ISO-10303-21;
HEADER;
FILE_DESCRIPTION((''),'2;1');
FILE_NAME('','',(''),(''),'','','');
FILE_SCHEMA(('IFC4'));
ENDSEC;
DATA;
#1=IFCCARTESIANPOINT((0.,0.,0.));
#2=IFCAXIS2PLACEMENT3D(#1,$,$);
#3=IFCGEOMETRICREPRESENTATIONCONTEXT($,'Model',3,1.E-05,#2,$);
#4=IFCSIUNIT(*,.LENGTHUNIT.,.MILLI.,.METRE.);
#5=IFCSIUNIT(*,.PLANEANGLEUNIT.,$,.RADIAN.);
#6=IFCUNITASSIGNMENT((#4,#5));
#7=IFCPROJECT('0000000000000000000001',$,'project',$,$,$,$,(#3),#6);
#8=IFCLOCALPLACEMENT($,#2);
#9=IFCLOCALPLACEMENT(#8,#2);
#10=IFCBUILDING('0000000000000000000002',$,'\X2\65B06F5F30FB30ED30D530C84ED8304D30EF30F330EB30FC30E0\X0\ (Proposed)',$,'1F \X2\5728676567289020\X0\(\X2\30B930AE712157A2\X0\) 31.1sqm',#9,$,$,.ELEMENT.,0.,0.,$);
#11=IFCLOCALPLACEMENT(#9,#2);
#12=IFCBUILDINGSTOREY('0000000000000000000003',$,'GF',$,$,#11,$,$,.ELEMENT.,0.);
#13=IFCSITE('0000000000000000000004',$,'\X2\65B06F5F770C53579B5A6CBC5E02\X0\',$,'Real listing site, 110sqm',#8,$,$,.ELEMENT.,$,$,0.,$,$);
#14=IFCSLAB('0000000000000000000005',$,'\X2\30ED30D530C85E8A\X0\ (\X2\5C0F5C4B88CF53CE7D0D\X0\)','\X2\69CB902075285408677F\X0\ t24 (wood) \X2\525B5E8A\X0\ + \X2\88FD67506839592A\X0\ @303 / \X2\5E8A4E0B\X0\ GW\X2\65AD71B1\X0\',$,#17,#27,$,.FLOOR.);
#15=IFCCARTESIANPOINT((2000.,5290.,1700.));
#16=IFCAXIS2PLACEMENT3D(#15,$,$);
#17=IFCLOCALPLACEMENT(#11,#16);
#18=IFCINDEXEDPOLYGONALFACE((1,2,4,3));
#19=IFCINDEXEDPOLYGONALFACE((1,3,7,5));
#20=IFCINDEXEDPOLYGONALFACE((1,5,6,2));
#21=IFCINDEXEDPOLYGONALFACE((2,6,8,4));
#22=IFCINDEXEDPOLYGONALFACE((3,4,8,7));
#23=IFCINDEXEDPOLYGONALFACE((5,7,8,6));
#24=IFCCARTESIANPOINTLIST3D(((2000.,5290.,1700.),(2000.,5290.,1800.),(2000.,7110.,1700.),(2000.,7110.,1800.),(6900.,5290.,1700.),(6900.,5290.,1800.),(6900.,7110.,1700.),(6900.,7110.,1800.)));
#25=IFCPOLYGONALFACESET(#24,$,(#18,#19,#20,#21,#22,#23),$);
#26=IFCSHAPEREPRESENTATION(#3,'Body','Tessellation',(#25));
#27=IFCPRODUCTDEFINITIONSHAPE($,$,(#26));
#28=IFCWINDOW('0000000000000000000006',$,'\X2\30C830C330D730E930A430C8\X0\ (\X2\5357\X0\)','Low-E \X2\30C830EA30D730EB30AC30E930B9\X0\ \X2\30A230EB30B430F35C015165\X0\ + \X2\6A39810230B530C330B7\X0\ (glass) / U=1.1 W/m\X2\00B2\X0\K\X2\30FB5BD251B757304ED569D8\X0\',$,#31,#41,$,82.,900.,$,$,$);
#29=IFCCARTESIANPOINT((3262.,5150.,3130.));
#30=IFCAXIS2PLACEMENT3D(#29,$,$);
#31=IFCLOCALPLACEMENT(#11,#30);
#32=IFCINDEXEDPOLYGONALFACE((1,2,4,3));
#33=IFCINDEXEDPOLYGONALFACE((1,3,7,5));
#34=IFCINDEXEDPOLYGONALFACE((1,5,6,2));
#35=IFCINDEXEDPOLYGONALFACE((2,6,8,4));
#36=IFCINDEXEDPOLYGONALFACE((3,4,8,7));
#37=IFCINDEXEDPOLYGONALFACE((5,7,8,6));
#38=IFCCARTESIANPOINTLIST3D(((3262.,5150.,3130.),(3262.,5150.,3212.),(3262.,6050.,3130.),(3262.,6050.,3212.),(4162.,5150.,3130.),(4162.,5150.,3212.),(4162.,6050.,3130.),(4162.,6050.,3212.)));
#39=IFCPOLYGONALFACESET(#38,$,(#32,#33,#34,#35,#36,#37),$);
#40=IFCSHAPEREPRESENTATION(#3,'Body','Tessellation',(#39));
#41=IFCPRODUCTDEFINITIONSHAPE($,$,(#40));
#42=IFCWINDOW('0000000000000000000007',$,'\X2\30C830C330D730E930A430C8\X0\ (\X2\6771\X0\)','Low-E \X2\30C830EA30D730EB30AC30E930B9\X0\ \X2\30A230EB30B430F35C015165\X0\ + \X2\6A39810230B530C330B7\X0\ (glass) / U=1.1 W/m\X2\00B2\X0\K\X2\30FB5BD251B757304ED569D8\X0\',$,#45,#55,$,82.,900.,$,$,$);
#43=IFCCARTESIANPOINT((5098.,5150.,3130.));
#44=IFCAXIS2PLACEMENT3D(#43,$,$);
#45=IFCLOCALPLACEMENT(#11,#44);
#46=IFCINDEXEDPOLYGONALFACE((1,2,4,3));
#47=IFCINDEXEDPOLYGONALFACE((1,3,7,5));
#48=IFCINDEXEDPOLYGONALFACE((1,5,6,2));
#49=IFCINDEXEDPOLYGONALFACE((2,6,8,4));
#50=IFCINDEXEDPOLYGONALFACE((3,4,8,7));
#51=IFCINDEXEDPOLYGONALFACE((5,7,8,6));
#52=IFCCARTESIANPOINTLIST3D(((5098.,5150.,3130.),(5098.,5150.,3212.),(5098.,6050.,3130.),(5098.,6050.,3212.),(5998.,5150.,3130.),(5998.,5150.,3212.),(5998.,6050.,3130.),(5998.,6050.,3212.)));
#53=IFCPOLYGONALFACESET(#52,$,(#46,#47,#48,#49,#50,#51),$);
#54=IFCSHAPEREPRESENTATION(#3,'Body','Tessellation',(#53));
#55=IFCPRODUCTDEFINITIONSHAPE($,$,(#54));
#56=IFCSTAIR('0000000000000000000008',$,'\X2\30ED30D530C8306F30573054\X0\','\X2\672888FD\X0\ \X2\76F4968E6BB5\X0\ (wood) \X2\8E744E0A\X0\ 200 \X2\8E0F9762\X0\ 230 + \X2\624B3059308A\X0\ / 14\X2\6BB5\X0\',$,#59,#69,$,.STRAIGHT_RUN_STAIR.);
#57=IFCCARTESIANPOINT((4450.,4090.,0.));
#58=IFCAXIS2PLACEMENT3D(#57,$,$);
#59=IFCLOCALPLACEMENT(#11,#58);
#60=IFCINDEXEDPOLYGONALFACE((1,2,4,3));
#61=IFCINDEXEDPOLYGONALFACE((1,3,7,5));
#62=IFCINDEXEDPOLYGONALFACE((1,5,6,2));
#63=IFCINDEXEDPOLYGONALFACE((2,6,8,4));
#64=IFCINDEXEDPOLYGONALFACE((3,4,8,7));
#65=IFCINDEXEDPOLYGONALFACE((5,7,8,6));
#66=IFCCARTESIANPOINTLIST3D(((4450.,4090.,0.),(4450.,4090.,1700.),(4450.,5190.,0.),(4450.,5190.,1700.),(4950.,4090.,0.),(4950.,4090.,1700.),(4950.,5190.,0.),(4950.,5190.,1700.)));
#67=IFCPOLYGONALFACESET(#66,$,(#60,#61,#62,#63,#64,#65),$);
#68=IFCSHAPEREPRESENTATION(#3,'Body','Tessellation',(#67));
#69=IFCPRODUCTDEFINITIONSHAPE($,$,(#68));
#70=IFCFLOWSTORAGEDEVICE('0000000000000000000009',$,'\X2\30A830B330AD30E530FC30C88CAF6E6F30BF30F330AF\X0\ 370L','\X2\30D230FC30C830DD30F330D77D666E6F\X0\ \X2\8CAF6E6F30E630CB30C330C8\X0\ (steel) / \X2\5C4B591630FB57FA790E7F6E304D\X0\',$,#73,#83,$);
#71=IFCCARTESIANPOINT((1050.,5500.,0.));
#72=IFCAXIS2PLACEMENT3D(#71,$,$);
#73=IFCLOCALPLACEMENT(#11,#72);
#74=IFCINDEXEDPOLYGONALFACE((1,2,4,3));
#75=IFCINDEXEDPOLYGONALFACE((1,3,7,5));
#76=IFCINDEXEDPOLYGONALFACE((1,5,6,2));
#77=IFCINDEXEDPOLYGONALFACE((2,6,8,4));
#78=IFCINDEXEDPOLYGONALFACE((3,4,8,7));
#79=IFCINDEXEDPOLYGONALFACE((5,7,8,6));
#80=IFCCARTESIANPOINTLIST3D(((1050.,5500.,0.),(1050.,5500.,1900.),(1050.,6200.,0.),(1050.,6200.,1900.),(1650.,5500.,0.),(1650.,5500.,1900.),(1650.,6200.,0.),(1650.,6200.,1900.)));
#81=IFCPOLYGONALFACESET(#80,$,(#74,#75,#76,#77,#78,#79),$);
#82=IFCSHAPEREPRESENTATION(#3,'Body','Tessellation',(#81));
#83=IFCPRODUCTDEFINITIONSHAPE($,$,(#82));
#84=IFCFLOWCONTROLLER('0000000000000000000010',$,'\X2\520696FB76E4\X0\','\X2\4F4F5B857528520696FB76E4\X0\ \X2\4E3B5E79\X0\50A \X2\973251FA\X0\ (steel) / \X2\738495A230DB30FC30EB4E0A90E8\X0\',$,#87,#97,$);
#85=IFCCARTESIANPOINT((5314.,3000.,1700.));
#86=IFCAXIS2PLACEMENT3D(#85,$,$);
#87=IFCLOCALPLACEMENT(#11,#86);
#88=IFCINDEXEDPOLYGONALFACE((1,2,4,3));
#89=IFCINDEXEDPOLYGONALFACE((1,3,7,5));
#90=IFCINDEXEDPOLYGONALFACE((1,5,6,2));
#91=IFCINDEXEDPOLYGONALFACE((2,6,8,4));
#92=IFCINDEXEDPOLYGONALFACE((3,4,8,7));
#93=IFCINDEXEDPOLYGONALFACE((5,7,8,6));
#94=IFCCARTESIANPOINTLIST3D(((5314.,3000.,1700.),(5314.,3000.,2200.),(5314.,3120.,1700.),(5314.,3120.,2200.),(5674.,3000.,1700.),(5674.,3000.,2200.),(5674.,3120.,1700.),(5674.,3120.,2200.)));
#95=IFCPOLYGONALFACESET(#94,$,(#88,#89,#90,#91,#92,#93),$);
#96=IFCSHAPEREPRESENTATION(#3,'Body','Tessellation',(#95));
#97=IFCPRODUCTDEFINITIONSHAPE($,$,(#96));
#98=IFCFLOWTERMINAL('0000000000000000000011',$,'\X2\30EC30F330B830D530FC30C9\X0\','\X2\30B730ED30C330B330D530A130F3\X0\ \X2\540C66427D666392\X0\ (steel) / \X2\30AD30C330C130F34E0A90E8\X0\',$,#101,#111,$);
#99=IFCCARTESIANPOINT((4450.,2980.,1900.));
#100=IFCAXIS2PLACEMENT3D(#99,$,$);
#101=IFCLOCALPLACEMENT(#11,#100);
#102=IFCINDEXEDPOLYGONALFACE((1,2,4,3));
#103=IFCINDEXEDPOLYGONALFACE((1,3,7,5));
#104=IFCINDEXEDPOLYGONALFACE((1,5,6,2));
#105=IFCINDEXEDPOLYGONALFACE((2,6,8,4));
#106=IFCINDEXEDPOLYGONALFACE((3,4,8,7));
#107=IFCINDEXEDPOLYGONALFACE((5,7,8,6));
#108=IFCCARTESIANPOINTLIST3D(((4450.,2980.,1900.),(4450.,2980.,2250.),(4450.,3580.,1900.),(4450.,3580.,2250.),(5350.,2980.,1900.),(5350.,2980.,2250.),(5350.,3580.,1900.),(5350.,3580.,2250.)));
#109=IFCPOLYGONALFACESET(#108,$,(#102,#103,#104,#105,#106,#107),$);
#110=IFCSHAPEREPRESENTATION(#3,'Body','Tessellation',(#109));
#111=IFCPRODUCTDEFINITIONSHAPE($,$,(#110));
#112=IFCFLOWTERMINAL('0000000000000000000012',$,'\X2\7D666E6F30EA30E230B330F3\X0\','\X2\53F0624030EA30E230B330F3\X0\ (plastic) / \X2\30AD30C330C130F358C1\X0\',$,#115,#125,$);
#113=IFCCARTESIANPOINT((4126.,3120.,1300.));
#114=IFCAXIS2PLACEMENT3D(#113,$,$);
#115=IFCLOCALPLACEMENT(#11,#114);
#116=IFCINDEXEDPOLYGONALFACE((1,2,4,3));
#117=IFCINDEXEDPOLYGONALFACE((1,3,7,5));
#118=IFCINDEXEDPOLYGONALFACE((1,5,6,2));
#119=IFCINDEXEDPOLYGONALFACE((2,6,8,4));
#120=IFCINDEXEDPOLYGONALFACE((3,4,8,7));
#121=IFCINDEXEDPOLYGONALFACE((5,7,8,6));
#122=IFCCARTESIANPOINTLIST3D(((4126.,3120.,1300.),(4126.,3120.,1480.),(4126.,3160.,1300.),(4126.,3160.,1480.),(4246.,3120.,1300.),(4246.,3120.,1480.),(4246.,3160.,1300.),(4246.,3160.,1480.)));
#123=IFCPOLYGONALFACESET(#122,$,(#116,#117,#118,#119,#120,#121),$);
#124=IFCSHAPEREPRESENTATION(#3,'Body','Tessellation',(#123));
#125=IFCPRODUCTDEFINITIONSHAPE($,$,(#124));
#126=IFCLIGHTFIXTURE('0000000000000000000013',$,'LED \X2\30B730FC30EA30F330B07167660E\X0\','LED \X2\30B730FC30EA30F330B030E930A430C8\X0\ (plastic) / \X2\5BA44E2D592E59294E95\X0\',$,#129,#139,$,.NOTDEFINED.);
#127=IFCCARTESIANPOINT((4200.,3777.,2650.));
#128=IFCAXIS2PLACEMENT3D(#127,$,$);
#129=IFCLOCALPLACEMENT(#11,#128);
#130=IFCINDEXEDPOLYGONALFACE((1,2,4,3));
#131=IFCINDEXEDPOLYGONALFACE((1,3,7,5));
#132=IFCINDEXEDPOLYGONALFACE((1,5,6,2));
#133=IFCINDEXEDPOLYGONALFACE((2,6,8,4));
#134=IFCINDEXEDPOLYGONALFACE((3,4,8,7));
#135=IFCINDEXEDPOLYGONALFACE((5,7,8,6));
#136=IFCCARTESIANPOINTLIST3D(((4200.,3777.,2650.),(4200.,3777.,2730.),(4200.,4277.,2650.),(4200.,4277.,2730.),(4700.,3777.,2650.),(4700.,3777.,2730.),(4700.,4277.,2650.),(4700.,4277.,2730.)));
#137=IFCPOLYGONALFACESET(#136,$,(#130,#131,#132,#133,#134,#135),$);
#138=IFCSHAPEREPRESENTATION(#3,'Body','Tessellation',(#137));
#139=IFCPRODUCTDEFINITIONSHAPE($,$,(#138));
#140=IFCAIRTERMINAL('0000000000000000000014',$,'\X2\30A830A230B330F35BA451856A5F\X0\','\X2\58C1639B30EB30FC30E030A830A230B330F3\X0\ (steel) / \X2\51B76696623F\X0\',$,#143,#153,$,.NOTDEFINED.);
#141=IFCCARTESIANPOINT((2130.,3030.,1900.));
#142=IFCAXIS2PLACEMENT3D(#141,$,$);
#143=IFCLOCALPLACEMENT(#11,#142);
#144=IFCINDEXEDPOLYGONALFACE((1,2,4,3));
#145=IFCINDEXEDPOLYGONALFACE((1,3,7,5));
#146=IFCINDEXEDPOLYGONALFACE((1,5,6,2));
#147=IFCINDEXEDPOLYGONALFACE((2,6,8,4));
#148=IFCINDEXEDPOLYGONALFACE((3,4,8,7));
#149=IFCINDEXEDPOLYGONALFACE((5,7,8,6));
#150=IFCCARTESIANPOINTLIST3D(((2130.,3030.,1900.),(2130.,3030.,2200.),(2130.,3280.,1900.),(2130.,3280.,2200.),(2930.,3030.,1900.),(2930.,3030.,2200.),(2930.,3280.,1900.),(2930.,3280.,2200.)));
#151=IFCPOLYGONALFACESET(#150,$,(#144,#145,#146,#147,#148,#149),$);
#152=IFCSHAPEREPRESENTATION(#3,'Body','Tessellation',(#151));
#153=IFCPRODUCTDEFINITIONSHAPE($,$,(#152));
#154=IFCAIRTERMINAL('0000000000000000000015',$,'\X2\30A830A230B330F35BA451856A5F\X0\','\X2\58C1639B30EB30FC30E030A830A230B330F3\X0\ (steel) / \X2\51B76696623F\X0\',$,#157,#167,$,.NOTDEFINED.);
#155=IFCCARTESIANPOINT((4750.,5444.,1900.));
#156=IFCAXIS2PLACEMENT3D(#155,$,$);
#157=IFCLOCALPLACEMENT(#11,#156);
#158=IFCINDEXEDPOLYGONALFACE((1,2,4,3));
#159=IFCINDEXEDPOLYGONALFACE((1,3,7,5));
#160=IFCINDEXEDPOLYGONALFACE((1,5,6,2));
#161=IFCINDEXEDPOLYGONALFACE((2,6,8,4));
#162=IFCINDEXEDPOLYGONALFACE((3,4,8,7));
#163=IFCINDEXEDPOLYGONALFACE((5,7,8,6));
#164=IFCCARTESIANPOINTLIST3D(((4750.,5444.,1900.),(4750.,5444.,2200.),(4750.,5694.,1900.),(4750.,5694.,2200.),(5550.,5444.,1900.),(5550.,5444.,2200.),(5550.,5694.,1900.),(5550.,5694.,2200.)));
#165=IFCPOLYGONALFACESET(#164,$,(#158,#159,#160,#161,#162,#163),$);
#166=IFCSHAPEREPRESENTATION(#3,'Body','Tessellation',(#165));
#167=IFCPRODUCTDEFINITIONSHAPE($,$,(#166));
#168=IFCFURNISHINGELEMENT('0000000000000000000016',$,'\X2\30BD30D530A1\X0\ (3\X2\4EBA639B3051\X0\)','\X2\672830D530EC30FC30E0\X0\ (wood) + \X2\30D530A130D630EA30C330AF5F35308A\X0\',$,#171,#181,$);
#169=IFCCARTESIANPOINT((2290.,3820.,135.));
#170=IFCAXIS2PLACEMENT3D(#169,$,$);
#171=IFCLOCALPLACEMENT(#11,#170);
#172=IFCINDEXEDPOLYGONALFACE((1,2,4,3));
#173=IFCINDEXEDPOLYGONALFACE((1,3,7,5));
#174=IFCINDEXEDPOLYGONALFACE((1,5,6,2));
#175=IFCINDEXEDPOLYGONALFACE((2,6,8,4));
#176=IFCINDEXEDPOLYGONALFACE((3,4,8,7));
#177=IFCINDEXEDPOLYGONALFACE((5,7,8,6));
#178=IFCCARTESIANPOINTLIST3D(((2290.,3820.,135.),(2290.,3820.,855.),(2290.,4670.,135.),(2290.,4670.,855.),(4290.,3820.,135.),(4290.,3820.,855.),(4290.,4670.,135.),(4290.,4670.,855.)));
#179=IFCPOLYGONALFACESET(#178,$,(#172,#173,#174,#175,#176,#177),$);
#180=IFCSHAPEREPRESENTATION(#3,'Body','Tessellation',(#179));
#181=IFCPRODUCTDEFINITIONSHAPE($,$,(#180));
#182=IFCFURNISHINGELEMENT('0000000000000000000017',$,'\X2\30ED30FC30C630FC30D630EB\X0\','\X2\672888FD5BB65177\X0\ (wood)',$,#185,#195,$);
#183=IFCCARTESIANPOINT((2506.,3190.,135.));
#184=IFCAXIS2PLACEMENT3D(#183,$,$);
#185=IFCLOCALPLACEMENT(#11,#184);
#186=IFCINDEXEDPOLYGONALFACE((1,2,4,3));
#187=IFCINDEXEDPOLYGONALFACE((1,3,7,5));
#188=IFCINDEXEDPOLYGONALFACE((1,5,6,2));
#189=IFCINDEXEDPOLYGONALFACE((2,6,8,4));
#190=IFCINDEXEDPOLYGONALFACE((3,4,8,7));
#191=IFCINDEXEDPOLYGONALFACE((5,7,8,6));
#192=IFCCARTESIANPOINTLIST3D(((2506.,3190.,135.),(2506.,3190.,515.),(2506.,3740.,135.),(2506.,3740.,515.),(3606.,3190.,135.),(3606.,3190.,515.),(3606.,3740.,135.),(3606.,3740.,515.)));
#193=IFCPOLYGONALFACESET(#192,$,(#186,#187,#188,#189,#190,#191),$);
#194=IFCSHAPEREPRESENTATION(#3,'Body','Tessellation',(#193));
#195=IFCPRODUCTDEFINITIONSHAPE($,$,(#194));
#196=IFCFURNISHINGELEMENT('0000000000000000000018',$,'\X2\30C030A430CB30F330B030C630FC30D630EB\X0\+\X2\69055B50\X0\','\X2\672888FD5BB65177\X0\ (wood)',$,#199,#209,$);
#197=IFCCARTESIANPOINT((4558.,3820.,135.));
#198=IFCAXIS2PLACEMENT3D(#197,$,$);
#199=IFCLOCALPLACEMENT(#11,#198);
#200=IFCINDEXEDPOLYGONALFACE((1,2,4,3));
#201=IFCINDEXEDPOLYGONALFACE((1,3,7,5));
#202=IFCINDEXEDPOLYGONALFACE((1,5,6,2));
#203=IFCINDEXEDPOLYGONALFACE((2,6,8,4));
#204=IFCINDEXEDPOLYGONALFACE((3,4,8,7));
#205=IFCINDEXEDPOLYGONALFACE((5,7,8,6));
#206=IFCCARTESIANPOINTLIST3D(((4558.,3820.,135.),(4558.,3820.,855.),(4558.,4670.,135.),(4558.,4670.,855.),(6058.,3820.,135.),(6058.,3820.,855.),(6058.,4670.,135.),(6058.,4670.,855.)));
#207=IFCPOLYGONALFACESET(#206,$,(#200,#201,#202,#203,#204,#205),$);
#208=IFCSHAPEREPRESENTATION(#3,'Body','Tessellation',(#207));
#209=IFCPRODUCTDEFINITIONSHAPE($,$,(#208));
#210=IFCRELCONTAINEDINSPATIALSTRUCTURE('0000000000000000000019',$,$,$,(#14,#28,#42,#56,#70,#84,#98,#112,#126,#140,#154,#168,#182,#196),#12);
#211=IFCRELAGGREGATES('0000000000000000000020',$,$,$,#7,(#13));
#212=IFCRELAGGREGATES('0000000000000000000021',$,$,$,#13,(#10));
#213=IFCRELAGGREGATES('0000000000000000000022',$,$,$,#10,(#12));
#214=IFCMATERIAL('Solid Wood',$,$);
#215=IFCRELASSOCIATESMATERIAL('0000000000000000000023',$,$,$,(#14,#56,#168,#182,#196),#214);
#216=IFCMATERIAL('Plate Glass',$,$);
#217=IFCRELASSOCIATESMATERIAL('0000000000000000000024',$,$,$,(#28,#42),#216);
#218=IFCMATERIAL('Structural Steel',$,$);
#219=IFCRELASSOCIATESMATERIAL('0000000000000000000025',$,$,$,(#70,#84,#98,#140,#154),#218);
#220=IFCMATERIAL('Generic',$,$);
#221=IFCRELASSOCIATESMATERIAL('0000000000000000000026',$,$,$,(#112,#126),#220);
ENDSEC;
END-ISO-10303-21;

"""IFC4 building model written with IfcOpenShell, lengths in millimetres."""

from ifc_helpers import new_model, si_unit, frame, frame_2d, origin, place, context, project, spatial, rectangle, extrude, material, element, save


model = new_model("IFC4")

# Units and contexts
model_context = context("Model", 3, precision=1e-05, world=origin())
ifc_project = project(units=[si_unit("LENGTHUNIT", "METRE", prefix="MILLI"), si_unit("PLANEANGLEUNIT", "RADIAN")], contexts=[model_context])

# Site, building, storey
site_placement = place(None, origin())
site = spatial("IfcSite", under=ifc_project, at=site_placement, Name="新潟県南魚沼市", ObjectType="Real listing site, 110sqm", CompositionType="ELEMENT", RefElevation=0.0)
building_placement = place(site_placement, origin())
building = spatial("IfcBuilding", under=site, at=building_placement, Name="新潟・ロフト付きワンルーム (Proposed)", ObjectType="1F 在来木造(スギ無垢) 31.1sqm", CompositionType="ELEMENT", ElevationOfRefHeight=0.0, ElevationOfTerrain=0.0)
storey_placement = place(building_placement, origin())
storey = spatial("IfcBuildingStorey", under=building, at=storey_placement, Name="GF", CompositionType="ELEMENT", Elevation=0.0)

# Shared definitions
ifc_material_1 = material(Name="Solid Wood")

# Slab
slab_placement = place(storey_placement, frame((2000.0, 5290.0, 1700.0)))
element("IfcSlab", 1, at=slab_placement, inside=storey, material=ifc_material_1, Name="ロフト床 (小屋裏収納)", Description="構造用合板 t24 (wood) 剛床 + 製材根太 @303 / 床下 GW断熱", PredefinedType="FLOOR", context=model_context, shape_type="SweptSolid", body=[
    extrude(rectangle(XDim=4900.0, YDim=1820.0, at=frame_2d((2450.0, 910.0))), frame((2000.0, 5290.0, 1700.0)), (0.0, 0.0, 1.0), 100.0),
])

# Windows
ifc_material_2 = material(Name="Plate Glass")
window_1_placement = place(storey_placement, frame((3262.0, 5150.0, 3130.0)))
element("IfcWindow", 2, at=window_1_placement, inside=storey, material=ifc_material_2, Name="トップライト (南)", Description="Low-E トリプルガラス アルゴン封入 + 樹脂サッシ (glass) / U=1.1 W/m²K・寒冷地仕様", OverallHeight=82.0, OverallWidth=900.0, context=model_context, shape_type="SweptSolid", body=[
    extrude(rectangle(XDim=900.0, YDim=900.0, at=frame_2d((450.0, 450.0))), frame((3262.0, 5150.0, 3130.0)), (0.0, 0.0, 1.0), 82.0),
])
window_2_placement = place(storey_placement, frame((5098.0, 5150.0, 3130.0)))
element("IfcWindow", 3, at=window_2_placement, inside=storey, material=ifc_material_2, Name="トップライト (東)", Description="Low-E トリプルガラス アルゴン封入 + 樹脂サッシ (glass) / U=1.1 W/m²K・寒冷地仕様", OverallHeight=82.0, OverallWidth=900.0, context=model_context, shape_type="SweptSolid", body=[
    extrude(rectangle(XDim=900.0, YDim=900.0, at=frame_2d((450.0, 450.0))), frame((5098.0, 5150.0, 3130.0)), (0.0, 0.0, 1.0), 82.0),
])

# Stair
stair_placement = place(storey_placement, frame((4450.0, 4090.0, 0.0)))
element("IfcStair", 4, at=stair_placement, inside=storey, material=ifc_material_1, Name="ロフトはしご", Description="木製 直階段 (wood) 蹴上 200 踏面 230 + 手すり / 14段", PredefinedType="STRAIGHT_RUN_STAIR", context=model_context, shape_type="SweptSolid", body=[
    extrude(rectangle(XDim=500.0, YDim=1100.0, at=frame_2d((250.0, 550.0))), frame((4450.0, 4090.0, 0.0)), (0.0, 0.0, 1.0), 1700.0),
])

# Flow storage device
ifc_material_3 = material(Name="Structural Steel")
flow_storage_device_placement = place(storey_placement, frame((1050.0, 5500.0, 0.0)))
element("IfcFlowStorageDevice", 5, at=flow_storage_device_placement, inside=storey, material=ifc_material_3, Name="エコキュート貯湯タンク 370L", Description="ヒートポンプ給湯 貯湯ユニット (steel) / 屋外・基礎置き", context=model_context, shape_type="SweptSolid", body=[
    extrude(rectangle(XDim=600.0, YDim=700.0, at=frame_2d((300.0, 350.0))), frame((1050.0, 5500.0, 0.0)), (0.0, 0.0, 1.0), 1900.0),
])

# Flow controller
flow_controller_placement = place(storey_placement, frame((5314.0, 3000.0, 1700.0)))
element("IfcFlowController", 6, at=flow_controller_placement, inside=storey, material=ifc_material_3, Name="分電盤", Description="住宅用分電盤 主幹50A 露出 (steel) / 玄関ホール上部", context=model_context, shape_type="SweptSolid", body=[
    extrude(rectangle(XDim=360.0, YDim=120.0, at=frame_2d((180.0, 60.0))), frame((5314.0, 3000.0, 1700.0)), (0.0, 0.0, 1.0), 500.0),
])

# Flow terminals
flow_terminal_1_placement = place(storey_placement, frame((4450.0, 2980.0, 1900.0)))
element("IfcFlowTerminal", 7, at=flow_terminal_1_placement, inside=storey, material=ifc_material_3, Name="レンジフード", Description="シロッコファン 同時給排 (steel) / キッチン上部", context=model_context, shape_type="SweptSolid", body=[
    extrude(rectangle(XDim=900.0, YDim=600.0, at=frame_2d((450.0, 300.0))), frame((4450.0, 2980.0, 1900.0)), (0.0, 0.0, 1.0), 350.0),
])
ifc_material_4 = material(Name="Generic")
flow_terminal_2_placement = place(storey_placement, frame((4126.0, 3120.0, 1300.0)))
element("IfcFlowTerminal", 8, at=flow_terminal_2_placement, inside=storey, material=ifc_material_4, Name="給湯リモコン", Description="台所リモコン (plastic) / キッチン壁", context=model_context, shape_type="SweptSolid", body=[
    extrude(rectangle(XDim=120.0, YDim=40.0, at=frame_2d((60.0, 20.0))), frame((4126.0, 3120.0, 1300.0)), (0.0, 0.0, 1.0), 180.0),
])

# Light fixture
light_fixture_placement = place(storey_placement, frame((4200.0, 3777.0, 2650.0)))
element("IfcLightFixture", 9, at=light_fixture_placement, inside=storey, material=ifc_material_4, Name="LED シーリング照明", Description="LED シーリングライト (plastic) / 室中央天井", PredefinedType="NOTDEFINED", context=model_context, shape_type="SweptSolid", body=[
    extrude(rectangle(XDim=500.0, YDim=500.0, at=frame_2d((250.0, 250.0))), frame((4200.0, 3777.0, 2650.0)), (0.0, 0.0, 1.0), 80.0),
])

# Air terminals
air_terminal_1_placement = place(storey_placement, frame((2130.0, 3030.0, 1900.0)))
element("IfcAirTerminal", 10, at=air_terminal_1_placement, inside=storey, material=ifc_material_3, Name="エアコン室内機", Description="壁掛ルームエアコン (steel) / 冷暖房", PredefinedType="NOTDEFINED", context=model_context, shape_type="SweptSolid", body=[
    extrude(rectangle(XDim=800.0, YDim=250.0, at=frame_2d((400.0, 125.0))), frame((2130.0, 3030.0, 1900.0)), (0.0, 0.0, 1.0), 300.0),
])
air_terminal_2_placement = place(storey_placement, frame((4750.0, 5444.0, 1900.0)))
element("IfcAirTerminal", 11, at=air_terminal_2_placement, inside=storey, material=ifc_material_3, Name="エアコン室内機", Description="壁掛ルームエアコン (steel) / 冷暖房", PredefinedType="NOTDEFINED", context=model_context, shape_type="SweptSolid", body=[
    extrude(rectangle(XDim=800.0, YDim=250.0, at=frame_2d((400.0, 125.0))), frame((4750.0, 5444.0, 1900.0)), (0.0, 0.0, 1.0), 300.0),
])

# Furnishing elements
furnishing_1_placement = place(storey_placement, frame((2290.0, 3820.0, 135.0)))
element("IfcFurnishingElement", 12, at=furnishing_1_placement, inside=storey, material=ifc_material_1, Name="ソファ (3人掛け)", Description="木フレーム (wood) + ファブリック張り", context=model_context, shape_type="SweptSolid", body=[
    extrude(rectangle(XDim=2000.0, YDim=850.0, at=frame_2d((1000.0, 425.0))), frame((2290.0, 3820.0, 135.0)), (0.0, 0.0, 1.0), 720.0),
])
furnishing_2_placement = place(storey_placement, frame((2506.0, 3190.0, 135.0)))
element("IfcFurnishingElement", 13, at=furnishing_2_placement, inside=storey, material=ifc_material_1, Name="ローテーブル", Description="木製家具 (wood)", context=model_context, shape_type="SweptSolid", body=[
    extrude(rectangle(XDim=1100.0, YDim=550.0, at=frame_2d((550.0, 275.0))), frame((2506.0, 3190.0, 135.0)), (0.0, 0.0, 1.0), 380.0),
])
furnishing_3_placement = place(storey_placement, frame((4558.0, 3820.0, 135.0)))
element("IfcFurnishingElement", 14, at=furnishing_3_placement, inside=storey, material=ifc_material_1, Name="ダイニングテーブル+椅子", Description="木製家具 (wood)", context=model_context, shape_type="SweptSolid", body=[
    extrude(rectangle(XDim=1500.0, YDim=850.0, at=frame_2d((750.0, 425.0))), frame((4558.0, 3820.0, 135.0)), (0.0, 0.0, 1.0), 720.0),
])

save(model, "model.ifc")
